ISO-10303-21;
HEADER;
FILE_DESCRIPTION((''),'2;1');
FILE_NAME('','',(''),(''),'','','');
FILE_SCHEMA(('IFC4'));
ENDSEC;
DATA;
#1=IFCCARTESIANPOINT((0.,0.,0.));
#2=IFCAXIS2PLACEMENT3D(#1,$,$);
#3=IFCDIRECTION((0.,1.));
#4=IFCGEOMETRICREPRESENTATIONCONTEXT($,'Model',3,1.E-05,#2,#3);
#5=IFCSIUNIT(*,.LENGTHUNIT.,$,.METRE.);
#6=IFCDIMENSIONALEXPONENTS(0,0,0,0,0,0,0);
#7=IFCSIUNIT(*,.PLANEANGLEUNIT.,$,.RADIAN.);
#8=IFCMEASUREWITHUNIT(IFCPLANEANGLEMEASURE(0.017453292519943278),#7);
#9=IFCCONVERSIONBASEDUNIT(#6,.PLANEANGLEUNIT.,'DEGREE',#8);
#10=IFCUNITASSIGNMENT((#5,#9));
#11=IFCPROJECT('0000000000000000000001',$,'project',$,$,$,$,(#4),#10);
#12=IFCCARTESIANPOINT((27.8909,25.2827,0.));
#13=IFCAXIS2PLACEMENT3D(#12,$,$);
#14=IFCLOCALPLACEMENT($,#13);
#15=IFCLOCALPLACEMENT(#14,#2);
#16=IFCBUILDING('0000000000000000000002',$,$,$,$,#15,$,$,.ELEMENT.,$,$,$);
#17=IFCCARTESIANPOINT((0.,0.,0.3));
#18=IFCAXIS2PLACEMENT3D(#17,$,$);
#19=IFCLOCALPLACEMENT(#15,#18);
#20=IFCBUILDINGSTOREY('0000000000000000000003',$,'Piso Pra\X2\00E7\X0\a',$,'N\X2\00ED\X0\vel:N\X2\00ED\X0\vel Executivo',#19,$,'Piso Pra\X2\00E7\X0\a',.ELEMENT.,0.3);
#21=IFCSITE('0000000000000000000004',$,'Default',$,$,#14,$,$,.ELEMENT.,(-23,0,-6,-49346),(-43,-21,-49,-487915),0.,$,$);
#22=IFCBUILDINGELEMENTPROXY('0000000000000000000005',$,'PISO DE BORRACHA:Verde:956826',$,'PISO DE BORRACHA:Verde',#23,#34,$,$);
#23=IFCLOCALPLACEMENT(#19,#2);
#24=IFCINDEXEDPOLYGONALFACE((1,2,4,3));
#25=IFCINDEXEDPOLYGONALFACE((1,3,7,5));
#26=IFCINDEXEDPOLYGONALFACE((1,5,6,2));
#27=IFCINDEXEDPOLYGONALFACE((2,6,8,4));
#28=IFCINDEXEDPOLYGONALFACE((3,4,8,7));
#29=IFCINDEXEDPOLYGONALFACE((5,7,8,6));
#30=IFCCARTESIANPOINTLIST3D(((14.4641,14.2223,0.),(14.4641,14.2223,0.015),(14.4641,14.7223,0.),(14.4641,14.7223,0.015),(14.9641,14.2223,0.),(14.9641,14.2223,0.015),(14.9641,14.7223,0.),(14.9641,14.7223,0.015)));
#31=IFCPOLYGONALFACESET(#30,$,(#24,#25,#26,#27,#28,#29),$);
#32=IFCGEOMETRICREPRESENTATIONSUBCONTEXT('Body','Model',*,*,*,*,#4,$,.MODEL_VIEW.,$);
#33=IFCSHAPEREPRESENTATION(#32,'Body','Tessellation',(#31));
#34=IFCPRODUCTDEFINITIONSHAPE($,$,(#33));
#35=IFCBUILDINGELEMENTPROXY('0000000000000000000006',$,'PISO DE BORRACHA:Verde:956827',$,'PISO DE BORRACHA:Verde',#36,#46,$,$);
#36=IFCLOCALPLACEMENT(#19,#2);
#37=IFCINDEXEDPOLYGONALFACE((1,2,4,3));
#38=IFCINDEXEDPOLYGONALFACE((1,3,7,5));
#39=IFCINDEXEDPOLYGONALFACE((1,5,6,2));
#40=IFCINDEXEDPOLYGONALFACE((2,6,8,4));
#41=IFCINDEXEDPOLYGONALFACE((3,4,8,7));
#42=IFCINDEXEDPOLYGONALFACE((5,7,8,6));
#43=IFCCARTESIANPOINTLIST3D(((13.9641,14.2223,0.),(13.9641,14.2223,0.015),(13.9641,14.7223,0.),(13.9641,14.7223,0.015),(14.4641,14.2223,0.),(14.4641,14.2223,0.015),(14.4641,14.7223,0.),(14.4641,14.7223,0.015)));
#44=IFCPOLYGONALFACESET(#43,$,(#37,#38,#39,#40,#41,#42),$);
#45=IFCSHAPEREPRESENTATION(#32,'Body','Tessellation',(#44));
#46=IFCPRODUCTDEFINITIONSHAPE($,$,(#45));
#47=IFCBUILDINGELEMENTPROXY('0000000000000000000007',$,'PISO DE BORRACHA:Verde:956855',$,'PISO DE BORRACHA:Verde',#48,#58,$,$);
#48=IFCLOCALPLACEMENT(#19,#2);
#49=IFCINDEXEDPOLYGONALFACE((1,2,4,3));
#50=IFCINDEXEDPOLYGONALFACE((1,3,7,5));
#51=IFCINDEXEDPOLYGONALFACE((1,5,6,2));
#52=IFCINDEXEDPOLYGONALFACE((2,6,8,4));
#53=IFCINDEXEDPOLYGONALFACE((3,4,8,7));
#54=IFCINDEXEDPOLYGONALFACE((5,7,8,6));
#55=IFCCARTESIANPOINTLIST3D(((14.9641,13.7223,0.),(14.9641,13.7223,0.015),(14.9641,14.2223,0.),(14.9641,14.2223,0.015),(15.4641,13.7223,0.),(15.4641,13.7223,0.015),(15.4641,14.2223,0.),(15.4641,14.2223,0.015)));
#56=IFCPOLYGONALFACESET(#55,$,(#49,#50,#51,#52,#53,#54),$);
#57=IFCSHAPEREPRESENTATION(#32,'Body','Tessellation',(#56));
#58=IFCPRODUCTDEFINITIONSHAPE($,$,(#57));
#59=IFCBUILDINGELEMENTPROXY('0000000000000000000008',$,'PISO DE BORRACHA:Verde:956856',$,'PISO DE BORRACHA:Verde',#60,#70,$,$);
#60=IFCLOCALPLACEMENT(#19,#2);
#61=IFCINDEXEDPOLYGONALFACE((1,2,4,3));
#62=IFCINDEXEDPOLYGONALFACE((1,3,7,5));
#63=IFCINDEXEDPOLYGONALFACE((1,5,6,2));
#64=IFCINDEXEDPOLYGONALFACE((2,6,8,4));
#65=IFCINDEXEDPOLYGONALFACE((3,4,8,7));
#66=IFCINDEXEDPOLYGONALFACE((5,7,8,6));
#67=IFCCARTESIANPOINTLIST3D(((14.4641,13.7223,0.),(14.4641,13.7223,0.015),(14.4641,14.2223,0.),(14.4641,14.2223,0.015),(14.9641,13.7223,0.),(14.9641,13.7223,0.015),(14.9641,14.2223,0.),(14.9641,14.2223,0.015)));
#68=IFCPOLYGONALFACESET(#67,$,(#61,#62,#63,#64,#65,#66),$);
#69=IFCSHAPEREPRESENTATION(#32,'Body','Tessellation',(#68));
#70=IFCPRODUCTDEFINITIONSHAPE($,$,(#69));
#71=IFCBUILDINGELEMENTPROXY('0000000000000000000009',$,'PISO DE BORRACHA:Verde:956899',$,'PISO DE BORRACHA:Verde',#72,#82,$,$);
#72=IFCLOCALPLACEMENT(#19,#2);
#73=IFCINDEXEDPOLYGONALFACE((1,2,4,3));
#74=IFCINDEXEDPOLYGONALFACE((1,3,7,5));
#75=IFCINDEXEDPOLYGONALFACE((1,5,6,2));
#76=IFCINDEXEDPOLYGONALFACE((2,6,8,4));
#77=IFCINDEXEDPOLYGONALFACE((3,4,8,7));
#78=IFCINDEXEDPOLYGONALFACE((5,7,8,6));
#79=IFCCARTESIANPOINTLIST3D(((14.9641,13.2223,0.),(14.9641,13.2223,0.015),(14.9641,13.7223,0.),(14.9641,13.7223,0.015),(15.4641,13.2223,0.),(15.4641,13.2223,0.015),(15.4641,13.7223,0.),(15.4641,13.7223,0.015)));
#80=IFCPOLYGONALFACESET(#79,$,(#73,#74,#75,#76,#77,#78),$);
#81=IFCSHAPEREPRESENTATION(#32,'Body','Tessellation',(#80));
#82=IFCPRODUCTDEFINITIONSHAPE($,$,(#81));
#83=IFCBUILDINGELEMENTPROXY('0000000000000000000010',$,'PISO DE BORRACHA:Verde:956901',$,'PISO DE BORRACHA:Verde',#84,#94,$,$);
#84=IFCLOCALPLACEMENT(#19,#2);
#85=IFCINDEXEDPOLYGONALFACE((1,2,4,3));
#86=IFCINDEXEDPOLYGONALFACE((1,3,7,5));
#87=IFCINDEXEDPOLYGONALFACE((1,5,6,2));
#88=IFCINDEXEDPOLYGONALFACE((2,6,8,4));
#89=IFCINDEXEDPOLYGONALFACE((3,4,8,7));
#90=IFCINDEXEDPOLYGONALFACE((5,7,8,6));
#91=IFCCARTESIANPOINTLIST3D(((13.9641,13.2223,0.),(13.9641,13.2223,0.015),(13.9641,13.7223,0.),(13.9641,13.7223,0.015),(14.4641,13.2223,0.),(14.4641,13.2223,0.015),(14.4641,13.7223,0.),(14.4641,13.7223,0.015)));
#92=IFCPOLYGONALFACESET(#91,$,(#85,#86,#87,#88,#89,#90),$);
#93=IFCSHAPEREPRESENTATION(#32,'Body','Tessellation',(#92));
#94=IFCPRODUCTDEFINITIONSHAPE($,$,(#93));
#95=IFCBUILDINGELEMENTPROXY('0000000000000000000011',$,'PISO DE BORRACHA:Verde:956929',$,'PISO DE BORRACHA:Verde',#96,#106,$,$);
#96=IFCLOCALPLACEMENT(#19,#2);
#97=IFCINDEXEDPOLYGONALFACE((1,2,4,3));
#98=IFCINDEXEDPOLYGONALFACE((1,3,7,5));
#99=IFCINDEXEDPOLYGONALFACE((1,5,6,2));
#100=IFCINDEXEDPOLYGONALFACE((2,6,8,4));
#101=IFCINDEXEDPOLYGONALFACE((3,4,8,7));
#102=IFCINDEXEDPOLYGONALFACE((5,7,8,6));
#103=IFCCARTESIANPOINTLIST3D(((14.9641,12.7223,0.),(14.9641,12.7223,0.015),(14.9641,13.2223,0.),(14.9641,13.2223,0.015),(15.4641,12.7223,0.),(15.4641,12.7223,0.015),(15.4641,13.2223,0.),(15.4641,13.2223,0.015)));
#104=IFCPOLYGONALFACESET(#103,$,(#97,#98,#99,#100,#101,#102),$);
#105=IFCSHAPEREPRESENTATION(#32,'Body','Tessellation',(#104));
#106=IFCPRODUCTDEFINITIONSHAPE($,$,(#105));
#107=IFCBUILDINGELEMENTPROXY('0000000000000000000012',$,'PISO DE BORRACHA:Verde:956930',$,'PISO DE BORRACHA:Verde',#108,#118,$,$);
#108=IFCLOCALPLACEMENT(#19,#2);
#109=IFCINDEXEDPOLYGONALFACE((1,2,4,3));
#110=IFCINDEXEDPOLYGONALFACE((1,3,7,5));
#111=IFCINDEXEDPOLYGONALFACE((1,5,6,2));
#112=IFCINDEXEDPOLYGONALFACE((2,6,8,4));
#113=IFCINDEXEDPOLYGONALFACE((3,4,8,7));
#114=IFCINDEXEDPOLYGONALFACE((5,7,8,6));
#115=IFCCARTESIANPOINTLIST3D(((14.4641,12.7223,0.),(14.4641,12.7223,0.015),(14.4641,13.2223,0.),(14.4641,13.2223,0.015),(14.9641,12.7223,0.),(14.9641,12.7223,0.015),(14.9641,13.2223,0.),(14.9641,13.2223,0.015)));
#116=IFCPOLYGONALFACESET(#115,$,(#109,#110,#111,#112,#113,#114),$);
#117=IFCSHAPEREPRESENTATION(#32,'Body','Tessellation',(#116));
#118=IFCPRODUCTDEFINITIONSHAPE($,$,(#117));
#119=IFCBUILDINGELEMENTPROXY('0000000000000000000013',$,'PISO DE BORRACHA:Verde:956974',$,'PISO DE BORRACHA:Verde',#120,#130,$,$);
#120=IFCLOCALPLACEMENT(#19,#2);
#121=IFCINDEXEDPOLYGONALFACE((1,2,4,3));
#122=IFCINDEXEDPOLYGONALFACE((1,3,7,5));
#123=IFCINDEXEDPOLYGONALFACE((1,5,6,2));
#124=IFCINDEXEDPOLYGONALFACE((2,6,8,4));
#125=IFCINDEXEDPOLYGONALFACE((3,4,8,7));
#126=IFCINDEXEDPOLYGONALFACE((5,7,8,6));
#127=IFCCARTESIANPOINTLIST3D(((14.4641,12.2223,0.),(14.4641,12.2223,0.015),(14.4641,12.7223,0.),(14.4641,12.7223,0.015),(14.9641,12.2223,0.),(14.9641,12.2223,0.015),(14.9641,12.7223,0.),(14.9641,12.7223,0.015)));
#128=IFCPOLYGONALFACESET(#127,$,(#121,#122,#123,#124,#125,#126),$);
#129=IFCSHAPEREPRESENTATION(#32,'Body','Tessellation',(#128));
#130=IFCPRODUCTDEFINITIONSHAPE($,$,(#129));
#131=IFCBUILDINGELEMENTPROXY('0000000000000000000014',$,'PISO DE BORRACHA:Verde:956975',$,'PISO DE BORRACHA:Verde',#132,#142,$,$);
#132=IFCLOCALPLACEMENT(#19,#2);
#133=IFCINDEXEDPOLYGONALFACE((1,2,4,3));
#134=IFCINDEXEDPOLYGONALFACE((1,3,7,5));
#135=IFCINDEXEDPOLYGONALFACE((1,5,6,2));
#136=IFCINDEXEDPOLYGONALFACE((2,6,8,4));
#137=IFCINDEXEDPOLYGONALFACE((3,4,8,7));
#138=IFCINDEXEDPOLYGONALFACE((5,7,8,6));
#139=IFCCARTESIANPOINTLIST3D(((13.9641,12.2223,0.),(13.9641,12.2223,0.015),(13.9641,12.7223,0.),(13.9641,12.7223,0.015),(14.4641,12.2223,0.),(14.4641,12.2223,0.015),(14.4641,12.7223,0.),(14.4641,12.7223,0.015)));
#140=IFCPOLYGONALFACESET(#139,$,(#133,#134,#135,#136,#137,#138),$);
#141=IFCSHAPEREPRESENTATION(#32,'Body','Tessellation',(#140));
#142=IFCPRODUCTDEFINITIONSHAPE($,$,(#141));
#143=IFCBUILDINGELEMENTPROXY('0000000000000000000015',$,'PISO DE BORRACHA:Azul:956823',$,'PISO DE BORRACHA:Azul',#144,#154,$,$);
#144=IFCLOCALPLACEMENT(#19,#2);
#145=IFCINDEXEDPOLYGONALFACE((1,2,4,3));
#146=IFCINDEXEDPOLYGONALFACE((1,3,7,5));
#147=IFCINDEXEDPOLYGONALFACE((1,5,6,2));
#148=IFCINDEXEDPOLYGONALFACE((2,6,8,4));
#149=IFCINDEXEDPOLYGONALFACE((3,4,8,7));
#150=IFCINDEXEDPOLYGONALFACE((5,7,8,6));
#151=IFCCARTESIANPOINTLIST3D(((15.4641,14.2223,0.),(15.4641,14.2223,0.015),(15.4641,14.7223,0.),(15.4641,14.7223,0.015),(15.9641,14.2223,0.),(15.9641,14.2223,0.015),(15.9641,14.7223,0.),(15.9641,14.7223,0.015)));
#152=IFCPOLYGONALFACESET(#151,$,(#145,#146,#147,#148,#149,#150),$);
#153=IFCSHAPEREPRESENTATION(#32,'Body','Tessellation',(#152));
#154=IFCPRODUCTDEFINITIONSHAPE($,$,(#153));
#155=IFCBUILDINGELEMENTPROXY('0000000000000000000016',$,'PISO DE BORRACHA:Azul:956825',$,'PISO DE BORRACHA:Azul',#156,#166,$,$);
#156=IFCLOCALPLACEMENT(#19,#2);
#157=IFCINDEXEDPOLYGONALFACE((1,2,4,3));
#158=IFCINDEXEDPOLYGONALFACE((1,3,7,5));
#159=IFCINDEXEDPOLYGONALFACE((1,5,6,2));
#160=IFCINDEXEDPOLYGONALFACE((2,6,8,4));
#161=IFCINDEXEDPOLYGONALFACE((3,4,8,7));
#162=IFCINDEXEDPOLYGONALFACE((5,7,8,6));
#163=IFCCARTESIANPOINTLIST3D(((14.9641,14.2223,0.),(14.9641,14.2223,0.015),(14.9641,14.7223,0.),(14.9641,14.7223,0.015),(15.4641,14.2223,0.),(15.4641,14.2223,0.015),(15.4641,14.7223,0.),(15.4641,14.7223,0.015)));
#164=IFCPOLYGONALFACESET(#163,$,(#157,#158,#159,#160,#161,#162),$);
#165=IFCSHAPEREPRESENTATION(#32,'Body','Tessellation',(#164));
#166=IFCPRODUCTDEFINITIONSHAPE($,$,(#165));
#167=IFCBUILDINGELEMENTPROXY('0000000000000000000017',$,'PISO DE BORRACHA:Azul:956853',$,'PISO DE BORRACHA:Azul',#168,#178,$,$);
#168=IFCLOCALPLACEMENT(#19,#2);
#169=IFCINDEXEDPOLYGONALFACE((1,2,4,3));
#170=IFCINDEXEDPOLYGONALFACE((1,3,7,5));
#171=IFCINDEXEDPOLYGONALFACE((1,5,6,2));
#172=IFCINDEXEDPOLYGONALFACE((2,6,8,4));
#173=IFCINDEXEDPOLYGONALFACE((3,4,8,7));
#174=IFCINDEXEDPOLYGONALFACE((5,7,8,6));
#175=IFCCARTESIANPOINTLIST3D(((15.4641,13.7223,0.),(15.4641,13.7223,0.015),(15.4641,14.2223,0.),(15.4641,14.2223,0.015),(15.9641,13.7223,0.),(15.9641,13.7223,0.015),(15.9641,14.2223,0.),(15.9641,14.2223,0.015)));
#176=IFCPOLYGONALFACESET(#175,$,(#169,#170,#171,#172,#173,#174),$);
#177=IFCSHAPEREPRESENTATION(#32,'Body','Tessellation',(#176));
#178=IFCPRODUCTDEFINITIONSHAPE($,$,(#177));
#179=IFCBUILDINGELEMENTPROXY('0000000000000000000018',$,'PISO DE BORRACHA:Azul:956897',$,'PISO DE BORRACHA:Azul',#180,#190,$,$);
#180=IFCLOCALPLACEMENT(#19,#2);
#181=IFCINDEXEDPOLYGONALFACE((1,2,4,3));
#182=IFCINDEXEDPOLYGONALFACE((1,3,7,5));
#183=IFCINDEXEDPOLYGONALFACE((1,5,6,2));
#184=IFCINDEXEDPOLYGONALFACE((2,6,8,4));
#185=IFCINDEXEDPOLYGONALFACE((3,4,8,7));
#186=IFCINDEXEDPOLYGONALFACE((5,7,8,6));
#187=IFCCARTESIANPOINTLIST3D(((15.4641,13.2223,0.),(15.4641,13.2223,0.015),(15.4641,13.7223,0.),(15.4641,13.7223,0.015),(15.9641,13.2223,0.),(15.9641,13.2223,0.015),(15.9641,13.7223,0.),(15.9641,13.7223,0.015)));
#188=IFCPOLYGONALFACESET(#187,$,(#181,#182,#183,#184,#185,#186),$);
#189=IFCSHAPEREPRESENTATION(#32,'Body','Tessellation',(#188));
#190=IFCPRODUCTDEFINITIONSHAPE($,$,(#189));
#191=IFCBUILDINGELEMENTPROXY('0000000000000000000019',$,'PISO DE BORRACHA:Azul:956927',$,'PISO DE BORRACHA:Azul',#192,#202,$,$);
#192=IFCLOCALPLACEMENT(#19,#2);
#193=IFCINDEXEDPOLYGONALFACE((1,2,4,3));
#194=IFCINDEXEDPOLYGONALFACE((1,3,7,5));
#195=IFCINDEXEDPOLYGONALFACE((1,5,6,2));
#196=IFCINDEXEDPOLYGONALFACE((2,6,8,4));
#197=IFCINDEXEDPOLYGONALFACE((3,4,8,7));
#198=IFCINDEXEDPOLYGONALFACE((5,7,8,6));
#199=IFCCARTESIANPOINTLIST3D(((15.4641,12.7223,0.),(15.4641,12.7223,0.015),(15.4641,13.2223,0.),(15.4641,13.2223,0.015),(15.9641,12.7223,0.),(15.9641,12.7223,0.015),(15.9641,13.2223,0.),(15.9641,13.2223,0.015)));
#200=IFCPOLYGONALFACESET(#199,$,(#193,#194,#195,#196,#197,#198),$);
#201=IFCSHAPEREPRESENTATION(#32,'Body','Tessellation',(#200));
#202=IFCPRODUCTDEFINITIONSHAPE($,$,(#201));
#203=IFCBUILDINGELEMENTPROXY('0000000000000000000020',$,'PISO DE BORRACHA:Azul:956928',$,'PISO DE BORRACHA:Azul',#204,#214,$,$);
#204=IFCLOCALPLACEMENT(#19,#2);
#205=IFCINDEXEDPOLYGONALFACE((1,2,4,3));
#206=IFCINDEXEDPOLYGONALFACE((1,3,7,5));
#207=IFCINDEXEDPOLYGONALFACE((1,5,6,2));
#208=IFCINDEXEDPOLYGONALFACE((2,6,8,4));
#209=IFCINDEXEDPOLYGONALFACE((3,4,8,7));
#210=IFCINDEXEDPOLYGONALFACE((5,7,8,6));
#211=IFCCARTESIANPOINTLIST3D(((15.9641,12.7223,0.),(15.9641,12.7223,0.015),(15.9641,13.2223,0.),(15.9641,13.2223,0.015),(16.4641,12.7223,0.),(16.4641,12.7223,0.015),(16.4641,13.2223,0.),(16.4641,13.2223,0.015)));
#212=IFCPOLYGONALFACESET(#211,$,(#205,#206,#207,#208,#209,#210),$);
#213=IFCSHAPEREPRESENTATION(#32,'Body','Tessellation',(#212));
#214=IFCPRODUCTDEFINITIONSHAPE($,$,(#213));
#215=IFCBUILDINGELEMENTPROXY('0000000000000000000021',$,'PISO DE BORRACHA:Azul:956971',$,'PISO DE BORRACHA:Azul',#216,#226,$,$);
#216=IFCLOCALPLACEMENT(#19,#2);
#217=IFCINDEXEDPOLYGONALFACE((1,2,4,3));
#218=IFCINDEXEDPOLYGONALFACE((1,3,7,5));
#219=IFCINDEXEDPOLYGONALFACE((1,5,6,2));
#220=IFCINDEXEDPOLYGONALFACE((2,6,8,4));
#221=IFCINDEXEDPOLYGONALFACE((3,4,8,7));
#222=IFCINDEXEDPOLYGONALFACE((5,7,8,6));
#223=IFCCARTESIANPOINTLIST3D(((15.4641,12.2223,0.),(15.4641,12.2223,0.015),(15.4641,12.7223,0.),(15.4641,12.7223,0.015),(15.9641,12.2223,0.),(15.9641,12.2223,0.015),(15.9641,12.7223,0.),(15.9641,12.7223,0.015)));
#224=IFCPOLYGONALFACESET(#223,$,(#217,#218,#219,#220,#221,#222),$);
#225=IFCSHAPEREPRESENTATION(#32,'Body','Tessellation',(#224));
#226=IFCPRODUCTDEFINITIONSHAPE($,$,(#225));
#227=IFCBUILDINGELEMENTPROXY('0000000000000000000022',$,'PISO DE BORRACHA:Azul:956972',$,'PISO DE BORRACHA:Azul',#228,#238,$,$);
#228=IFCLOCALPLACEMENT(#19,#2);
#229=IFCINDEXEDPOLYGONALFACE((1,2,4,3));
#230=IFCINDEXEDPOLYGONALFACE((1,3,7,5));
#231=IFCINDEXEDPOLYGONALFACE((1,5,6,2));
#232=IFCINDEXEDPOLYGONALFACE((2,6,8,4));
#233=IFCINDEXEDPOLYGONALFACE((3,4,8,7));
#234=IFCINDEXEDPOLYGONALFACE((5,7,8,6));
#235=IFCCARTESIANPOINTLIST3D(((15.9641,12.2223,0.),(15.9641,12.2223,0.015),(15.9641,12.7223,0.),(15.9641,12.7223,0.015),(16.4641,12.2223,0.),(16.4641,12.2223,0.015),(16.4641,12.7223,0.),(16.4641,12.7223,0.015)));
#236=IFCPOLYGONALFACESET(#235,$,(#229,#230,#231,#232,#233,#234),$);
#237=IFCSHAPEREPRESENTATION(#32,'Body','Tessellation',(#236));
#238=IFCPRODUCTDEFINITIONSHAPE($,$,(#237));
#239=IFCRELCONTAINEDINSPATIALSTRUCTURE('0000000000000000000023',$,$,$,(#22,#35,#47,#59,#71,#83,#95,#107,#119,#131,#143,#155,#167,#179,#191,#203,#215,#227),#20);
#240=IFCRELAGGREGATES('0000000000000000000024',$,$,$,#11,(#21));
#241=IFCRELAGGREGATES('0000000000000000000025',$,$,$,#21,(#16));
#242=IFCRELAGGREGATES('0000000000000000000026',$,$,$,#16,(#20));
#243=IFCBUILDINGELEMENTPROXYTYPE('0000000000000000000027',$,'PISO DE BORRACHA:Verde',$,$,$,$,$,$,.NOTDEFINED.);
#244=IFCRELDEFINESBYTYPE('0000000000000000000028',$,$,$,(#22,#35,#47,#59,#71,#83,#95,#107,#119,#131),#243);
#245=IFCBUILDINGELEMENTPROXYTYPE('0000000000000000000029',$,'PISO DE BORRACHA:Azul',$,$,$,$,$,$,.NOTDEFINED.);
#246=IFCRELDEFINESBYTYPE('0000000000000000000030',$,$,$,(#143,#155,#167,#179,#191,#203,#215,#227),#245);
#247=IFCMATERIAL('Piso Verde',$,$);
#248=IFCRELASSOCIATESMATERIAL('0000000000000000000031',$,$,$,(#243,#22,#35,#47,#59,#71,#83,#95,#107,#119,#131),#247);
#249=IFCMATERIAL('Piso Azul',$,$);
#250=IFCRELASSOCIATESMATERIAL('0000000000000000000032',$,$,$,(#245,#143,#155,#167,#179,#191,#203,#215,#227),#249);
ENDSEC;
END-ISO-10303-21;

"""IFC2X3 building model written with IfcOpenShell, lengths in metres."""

from ifc_helpers import new_model, entity, si_unit, converted_unit, direction, frame, origin, origin_2d_with_axis, place, context, subcontext, project, spatial, rectangle, extrude, source, transform, mapped, material, type_object, type_shapes, element, save


model = new_model("IFC2X3")

# Units and contexts
model_context = context("Model", 3, precision=1e-05, world=origin(), true_north=direction((0.0, 1.0)))
body_context = subcontext(model_context, "Body", "Model", "MODEL_VIEW")
ifc_project = project(units=[si_unit("LENGTHUNIT", "METRE"), converted_unit("PLANEANGLEUNIT", "DEGREE", entity("IfcPlaneAngleMeasure", 0.017453292519943278), si_unit("PLANEANGLEUNIT", "RADIAN"), dimensions=[0, 0, 0, 0, 0, 0, 0])], contexts=[model_context])

# Site, building, storey
site_placement = place(None, frame((27.8909, 25.2827, 0.0)))
site = spatial("IfcSite", under=ifc_project, at=site_placement, Name="Default", CompositionType="ELEMENT", RefLatitude=(-23, 0, -6, -49346), RefLongitude=(-43, -21, -49, -487915), RefElevation=0.0)
building_placement = place(site_placement, origin())
building = spatial("IfcBuilding", under=site, at=building_placement, CompositionType="ELEMENT")
storey_placement = place(building_placement, frame((0.0, 0.0, 0.3)))
storey = spatial("IfcBuildingStorey", under=building, at=storey_placement, Name="Piso Praça", ObjectType="Nível:Nível Executivo", LongName="Piso Praça", CompositionType="ELEMENT", Elevation=0.3)

# Building element proxies
ifc_material_1 = material(Name="Piso Verde")
building_element_proxy_type_1 = type_object("IfcBuildingElementProxyType", Name="PISO DE BORRACHA:Verde", PredefinedType="NOTDEFINED", material=ifc_material_1)
shared_shape_1 = source(origin(), body_context, "Body", "SweptSolid", [
    extrude(rectangle(XDim=0.5, YDim=0.5, at=origin_2d_with_axis()), frame((0.25, 0.25, 0.0), z_axis=(0.0, 0.0, 1.0), x_axis=(-1.0, 0.0, 0.0)), (0.0, 0.0, 1.0), 0.015),
])
type_shapes(building_element_proxy_type_1, [shared_shape_1])
for number, where, name in (
    (1, (14.4641, 14.2223, 0.0), "PISO DE BORRACHA:Verde:956826"),
    (2, (13.9641, 14.2223, 0.0), "PISO DE BORRACHA:Verde:956827"),
    (3, (14.9641, 13.7223, 0.0), "PISO DE BORRACHA:Verde:956855"),
    (4, (14.4641, 13.7223, 0.0), "PISO DE BORRACHA:Verde:956856"),
    (5, (14.9641, 13.2223, 0.0), "PISO DE BORRACHA:Verde:956899"),
    (6, (13.9641, 13.2223, 0.0), "PISO DE BORRACHA:Verde:956901"),
    (7, (14.9641, 12.7223, 0.0), "PISO DE BORRACHA:Verde:956929"),
    (8, (14.4641, 12.7223, 0.0), "PISO DE BORRACHA:Verde:956930"),
    (9, (14.4641, 12.2223, 0.0), "PISO DE BORRACHA:Verde:956974"),
    (10, (13.9641, 12.2223, 0.0), "PISO DE BORRACHA:Verde:956975"),
):
    element("IfcBuildingElementProxy", number, at=place(storey_placement, frame(where)), inside=storey, type_object=building_element_proxy_type_1, material=ifc_material_1, Name=name, ObjectType="PISO DE BORRACHA:Verde", context=body_context, shape_type="MappedRepresentation", body=[
        mapped(shared_shape_1, transform((0.0, 0.0, 0.0), scale=1.0)),
    ])
ifc_material_2 = material(Name="Piso Azul")
building_element_proxy_type_2 = type_object("IfcBuildingElementProxyType", Name="PISO DE BORRACHA:Azul", PredefinedType="NOTDEFINED", material=ifc_material_2)
shared_shape_2 = source(origin(), body_context, "Body", "SweptSolid", [
    extrude(rectangle(XDim=0.5, YDim=0.5, at=origin_2d_with_axis()), frame((0.25, 0.25, 0.0), z_axis=(0.0, 0.0, 1.0), x_axis=(-1.0, 0.0, 0.0)), (0.0, 0.0, 1.0), 0.015),
])
type_shapes(building_element_proxy_type_2, [shared_shape_2])
for number, where, name in (
    (11, (15.4641, 14.2223, 0.0), "PISO DE BORRACHA:Azul:956823"),
    (12, (14.9641, 14.2223, 0.0), "PISO DE BORRACHA:Azul:956825"),
    (13, (15.4641, 13.7223, 0.0), "PISO DE BORRACHA:Azul:956853"),
    (14, (15.4641, 13.2223, 0.0), "PISO DE BORRACHA:Azul:956897"),
    (15, (15.4641, 12.7223, 0.0), "PISO DE BORRACHA:Azul:956927"),
    (16, (15.9641, 12.7223, 0.0), "PISO DE BORRACHA:Azul:956928"),
    (17, (15.4641, 12.2223, 0.0), "PISO DE BORRACHA:Azul:956971"),
    (18, (15.9641, 12.2223, 0.0), "PISO DE BORRACHA:Azul:956972"),
):
    element("IfcBuildingElementProxy", number, at=place(storey_placement, frame(where)), inside=storey, type_object=building_element_proxy_type_2, material=ifc_material_2, Name=name, ObjectType="PISO DE BORRACHA:Azul", context=body_context, shape_type="MappedRepresentation", body=[
        mapped(shared_shape_2, transform((0.0, 0.0, 0.0), scale=1.0)),
    ])

save(model, "model.ifc")
